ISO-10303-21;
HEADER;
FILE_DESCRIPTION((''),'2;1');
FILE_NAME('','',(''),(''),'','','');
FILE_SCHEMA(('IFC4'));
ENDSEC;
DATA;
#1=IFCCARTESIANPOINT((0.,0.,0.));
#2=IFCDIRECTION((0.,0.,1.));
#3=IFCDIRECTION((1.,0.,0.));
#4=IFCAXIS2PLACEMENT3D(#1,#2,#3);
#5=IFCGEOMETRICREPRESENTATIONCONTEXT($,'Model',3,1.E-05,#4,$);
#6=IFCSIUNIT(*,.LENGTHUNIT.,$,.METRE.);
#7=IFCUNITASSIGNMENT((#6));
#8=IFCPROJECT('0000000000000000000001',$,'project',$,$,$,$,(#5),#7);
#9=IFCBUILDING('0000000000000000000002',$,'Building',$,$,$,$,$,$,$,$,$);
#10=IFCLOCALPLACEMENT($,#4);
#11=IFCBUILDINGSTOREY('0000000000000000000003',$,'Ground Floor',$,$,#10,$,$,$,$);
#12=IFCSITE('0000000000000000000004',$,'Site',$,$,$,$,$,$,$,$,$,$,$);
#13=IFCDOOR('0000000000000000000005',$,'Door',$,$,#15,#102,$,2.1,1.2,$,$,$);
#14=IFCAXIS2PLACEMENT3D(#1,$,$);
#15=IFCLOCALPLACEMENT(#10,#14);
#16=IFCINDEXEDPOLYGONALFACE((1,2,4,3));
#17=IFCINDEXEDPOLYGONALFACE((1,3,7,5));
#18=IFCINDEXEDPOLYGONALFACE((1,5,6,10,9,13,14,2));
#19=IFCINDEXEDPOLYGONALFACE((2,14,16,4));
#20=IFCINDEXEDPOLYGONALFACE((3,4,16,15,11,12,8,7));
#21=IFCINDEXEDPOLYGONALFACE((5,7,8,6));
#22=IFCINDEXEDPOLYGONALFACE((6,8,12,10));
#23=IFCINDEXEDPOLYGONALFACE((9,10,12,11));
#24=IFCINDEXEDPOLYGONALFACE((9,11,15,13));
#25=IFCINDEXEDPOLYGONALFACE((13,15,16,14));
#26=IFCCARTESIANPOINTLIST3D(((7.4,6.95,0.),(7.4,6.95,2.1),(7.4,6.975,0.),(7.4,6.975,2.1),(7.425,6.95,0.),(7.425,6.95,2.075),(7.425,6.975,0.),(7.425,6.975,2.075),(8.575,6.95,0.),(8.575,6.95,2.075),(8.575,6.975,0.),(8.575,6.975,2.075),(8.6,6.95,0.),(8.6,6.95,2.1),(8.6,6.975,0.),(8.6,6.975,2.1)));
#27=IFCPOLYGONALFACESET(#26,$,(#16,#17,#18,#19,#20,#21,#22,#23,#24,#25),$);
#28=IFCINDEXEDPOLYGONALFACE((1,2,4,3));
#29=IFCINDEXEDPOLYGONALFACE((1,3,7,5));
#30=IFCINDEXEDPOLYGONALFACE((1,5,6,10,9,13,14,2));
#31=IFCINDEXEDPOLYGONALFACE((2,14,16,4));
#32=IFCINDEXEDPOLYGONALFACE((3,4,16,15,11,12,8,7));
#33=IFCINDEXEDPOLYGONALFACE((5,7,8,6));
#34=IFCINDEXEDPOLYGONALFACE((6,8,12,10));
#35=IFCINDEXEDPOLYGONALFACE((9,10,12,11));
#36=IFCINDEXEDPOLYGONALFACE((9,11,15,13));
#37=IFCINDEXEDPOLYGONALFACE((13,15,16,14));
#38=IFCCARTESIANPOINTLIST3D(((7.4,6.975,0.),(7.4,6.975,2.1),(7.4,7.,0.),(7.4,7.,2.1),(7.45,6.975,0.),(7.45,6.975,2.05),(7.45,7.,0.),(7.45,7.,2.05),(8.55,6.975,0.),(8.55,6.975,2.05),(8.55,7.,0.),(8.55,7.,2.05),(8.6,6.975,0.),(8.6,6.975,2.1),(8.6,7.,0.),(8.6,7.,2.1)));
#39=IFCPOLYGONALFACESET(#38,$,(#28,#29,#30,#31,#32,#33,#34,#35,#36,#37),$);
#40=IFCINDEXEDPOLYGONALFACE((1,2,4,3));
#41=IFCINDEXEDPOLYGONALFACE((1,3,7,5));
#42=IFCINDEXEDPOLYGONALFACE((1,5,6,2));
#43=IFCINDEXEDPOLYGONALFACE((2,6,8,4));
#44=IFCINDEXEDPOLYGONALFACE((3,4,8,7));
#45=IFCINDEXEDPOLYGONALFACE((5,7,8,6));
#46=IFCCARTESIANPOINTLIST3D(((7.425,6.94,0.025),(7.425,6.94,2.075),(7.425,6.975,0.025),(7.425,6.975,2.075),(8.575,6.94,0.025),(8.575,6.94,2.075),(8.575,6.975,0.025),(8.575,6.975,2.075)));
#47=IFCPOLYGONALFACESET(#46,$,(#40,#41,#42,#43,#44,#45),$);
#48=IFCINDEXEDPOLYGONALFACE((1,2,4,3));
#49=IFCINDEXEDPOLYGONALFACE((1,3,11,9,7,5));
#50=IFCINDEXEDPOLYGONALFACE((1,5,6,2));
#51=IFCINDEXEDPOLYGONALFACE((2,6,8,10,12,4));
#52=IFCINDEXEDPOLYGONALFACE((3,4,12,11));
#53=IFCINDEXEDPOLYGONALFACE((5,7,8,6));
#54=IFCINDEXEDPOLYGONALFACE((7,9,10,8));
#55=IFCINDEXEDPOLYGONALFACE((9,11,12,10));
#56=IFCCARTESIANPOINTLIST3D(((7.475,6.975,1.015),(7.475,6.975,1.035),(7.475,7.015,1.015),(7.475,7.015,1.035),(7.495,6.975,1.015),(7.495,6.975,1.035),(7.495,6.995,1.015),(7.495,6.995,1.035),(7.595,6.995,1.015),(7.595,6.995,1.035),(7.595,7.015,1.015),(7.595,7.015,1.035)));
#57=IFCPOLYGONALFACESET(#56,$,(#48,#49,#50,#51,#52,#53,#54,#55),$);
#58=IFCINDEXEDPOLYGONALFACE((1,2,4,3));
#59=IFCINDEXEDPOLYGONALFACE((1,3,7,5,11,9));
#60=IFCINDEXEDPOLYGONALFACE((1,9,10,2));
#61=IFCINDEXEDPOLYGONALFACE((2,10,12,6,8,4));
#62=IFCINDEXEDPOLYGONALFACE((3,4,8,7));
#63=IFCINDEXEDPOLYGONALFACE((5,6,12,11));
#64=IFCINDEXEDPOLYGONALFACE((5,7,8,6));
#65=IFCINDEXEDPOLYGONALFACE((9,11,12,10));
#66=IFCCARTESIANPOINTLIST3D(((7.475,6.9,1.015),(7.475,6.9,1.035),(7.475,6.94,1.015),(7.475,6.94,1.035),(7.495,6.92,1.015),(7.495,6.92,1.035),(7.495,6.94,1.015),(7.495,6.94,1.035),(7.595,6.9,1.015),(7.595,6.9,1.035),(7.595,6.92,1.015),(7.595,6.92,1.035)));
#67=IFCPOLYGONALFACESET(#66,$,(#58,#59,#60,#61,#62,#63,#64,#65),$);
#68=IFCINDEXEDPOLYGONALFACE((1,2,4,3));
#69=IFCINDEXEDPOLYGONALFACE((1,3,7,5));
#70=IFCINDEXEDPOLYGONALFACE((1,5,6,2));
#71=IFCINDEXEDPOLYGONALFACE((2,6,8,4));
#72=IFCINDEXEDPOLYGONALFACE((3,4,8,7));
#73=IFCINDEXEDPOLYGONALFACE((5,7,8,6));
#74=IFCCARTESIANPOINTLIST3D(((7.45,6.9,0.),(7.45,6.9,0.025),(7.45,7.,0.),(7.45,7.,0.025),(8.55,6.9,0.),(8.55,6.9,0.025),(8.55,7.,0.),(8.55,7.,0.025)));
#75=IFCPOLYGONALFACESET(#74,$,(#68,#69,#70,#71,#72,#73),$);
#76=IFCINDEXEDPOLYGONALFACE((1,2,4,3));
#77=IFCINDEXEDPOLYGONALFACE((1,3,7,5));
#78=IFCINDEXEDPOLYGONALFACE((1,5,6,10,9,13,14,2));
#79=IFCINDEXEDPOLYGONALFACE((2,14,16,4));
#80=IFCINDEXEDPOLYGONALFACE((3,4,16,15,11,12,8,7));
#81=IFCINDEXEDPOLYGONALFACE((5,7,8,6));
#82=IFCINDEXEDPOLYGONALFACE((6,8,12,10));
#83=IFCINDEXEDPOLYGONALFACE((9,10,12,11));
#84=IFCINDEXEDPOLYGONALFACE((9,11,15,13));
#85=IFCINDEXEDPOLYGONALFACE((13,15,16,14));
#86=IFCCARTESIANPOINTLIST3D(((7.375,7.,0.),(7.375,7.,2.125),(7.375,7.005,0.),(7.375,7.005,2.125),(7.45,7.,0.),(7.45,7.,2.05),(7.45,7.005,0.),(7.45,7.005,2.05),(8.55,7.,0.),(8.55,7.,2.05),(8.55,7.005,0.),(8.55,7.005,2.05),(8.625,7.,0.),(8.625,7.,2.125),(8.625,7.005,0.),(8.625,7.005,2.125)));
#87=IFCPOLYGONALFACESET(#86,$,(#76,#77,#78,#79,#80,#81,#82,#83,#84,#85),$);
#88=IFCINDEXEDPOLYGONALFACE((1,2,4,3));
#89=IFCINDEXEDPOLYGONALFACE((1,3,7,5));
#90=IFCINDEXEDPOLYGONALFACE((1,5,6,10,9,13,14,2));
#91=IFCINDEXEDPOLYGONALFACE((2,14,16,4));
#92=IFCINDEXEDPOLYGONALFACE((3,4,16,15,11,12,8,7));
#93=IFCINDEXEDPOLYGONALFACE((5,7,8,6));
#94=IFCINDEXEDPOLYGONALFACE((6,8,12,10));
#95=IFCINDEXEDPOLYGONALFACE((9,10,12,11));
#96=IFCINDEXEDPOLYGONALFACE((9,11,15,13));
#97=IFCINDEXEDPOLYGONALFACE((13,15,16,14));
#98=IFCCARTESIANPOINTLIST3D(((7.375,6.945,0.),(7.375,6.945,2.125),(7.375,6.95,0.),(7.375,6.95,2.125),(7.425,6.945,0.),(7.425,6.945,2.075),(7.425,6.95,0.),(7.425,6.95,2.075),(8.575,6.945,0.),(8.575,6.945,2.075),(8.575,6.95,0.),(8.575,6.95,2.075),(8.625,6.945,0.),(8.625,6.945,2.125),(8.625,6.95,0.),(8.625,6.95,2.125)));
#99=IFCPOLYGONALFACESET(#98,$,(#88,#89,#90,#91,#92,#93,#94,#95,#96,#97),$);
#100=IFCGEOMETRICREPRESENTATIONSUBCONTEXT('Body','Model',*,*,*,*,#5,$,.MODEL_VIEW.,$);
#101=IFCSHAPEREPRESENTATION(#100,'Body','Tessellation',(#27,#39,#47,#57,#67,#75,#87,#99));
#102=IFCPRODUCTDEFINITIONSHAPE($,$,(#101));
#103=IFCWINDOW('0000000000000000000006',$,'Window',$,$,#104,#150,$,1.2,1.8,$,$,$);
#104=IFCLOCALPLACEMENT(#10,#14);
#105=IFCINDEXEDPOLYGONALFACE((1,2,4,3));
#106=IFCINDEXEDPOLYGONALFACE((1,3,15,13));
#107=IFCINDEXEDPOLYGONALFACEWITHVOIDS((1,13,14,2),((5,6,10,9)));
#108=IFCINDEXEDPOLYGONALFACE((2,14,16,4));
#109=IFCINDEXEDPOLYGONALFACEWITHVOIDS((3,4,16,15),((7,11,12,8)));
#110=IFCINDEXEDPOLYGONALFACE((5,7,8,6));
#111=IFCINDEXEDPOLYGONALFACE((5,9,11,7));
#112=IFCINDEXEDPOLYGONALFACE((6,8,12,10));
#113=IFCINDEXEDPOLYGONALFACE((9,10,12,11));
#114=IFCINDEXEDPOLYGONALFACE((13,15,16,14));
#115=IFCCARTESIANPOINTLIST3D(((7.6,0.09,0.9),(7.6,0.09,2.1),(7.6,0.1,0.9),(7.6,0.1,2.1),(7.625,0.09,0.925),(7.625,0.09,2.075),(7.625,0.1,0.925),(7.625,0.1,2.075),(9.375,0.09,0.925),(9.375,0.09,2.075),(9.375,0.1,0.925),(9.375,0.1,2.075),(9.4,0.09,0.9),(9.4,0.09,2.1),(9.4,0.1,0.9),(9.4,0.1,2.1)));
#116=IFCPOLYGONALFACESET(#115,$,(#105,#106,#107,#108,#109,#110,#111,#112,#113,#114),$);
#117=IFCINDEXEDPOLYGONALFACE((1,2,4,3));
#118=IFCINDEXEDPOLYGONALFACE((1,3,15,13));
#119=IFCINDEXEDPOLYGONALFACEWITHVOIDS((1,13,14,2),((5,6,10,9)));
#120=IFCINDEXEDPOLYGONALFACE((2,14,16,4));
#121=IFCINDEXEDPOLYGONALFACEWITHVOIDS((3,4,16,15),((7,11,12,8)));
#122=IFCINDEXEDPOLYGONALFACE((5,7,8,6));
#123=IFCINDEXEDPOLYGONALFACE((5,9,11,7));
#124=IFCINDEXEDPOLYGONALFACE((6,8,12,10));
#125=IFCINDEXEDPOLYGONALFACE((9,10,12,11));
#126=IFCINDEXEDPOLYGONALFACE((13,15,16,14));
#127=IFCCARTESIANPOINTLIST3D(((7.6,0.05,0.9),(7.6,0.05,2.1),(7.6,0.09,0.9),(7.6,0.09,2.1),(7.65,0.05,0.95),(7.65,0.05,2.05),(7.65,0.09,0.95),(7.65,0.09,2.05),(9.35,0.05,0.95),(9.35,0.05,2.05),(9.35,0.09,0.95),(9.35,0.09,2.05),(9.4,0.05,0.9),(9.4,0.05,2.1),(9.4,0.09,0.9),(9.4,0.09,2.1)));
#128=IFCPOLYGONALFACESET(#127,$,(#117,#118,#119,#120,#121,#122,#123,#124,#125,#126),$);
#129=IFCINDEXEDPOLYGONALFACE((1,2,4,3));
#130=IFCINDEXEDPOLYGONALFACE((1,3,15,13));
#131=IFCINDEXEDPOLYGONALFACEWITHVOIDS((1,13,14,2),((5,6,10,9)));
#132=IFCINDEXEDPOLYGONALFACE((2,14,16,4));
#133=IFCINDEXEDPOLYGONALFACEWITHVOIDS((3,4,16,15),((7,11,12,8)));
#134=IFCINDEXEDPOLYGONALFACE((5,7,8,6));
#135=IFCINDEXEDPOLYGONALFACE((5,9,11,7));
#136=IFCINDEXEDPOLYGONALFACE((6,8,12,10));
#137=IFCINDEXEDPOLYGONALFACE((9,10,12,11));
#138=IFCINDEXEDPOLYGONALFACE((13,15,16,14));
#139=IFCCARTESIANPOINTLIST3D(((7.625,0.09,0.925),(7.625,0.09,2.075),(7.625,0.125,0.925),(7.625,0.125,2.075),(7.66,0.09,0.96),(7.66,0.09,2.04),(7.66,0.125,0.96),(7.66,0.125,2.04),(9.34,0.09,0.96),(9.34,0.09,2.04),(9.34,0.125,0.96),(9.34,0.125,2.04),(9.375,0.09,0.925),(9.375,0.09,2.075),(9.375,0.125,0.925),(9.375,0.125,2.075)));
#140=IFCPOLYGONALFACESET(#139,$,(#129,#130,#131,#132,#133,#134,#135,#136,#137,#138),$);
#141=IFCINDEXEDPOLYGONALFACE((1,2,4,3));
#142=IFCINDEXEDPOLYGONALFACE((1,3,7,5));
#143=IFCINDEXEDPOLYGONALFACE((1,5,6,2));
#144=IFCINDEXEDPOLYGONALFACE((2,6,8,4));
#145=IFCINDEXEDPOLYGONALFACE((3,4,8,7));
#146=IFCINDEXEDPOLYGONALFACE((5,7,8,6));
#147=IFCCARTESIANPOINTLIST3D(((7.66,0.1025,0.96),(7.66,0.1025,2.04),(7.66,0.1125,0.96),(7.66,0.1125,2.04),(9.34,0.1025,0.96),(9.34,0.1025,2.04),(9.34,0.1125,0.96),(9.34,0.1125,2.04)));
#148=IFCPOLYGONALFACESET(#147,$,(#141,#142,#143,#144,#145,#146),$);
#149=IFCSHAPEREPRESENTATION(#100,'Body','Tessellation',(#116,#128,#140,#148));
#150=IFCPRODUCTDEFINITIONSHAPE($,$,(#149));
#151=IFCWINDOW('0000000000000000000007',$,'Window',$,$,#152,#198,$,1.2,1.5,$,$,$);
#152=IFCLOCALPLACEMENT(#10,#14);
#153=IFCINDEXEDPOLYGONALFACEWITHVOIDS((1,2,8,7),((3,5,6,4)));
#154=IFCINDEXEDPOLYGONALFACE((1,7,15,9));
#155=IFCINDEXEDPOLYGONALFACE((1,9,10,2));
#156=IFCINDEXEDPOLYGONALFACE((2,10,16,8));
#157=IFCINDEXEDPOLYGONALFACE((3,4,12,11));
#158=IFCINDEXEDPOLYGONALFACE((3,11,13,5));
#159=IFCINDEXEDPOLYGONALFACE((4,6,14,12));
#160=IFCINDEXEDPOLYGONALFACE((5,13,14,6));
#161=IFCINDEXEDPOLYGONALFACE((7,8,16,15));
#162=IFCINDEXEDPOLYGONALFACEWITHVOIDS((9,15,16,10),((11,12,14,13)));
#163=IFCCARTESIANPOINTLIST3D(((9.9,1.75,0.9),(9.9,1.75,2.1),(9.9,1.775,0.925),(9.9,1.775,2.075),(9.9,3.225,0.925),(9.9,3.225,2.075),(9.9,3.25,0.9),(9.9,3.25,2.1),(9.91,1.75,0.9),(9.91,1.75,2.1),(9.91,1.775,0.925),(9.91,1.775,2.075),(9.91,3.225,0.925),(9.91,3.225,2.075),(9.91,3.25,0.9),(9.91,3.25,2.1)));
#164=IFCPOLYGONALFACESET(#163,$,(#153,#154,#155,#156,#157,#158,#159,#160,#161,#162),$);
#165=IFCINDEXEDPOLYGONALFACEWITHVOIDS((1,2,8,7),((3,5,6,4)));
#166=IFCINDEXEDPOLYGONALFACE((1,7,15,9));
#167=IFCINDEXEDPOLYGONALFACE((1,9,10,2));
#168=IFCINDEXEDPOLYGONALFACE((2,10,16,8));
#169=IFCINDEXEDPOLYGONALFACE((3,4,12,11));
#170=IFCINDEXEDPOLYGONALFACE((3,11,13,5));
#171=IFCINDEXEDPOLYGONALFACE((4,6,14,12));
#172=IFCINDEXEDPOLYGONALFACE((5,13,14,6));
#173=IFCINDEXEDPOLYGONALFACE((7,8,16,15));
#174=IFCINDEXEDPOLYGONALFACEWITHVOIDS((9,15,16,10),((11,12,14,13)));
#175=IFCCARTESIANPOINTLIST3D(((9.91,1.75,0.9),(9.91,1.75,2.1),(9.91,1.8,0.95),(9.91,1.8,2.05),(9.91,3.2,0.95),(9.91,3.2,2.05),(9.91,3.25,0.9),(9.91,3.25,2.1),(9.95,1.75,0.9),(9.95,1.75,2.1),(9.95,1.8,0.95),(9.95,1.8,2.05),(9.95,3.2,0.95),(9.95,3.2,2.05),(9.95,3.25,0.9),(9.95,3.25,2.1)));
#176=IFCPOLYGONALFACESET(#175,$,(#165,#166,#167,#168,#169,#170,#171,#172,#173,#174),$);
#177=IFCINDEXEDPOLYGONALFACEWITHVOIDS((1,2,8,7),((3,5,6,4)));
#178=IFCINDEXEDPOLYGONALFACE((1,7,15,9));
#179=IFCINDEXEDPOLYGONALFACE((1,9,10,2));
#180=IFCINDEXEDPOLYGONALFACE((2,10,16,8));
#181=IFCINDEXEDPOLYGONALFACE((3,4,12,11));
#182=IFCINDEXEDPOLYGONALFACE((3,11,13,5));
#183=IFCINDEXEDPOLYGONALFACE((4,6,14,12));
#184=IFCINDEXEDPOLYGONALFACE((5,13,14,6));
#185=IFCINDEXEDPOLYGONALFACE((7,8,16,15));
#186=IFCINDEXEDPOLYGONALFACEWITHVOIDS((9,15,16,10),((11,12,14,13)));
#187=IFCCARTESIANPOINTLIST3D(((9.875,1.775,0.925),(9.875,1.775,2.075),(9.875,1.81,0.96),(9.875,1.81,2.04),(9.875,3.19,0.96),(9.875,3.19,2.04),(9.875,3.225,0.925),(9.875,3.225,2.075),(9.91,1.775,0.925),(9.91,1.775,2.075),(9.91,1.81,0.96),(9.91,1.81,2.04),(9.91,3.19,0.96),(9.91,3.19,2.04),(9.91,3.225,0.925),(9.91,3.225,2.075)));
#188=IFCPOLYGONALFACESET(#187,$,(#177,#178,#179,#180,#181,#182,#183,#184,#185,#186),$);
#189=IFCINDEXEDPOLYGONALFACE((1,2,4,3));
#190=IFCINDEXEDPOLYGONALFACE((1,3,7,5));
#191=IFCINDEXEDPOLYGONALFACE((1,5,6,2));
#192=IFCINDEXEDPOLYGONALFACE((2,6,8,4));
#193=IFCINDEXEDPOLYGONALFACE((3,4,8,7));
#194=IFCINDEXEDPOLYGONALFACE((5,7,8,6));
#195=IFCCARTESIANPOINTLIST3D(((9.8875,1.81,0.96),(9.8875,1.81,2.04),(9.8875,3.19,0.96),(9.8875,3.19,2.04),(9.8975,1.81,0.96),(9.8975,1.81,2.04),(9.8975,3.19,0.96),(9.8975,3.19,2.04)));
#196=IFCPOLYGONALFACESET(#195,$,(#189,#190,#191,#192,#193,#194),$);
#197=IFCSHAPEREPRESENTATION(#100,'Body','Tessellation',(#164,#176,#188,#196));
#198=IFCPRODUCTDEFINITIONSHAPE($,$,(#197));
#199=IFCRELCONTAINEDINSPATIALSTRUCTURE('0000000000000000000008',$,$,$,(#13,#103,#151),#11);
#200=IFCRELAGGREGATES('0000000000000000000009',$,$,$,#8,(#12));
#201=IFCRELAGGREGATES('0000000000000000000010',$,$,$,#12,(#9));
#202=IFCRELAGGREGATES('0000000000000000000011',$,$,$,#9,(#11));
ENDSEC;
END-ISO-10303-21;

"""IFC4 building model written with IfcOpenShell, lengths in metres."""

from ifc_helpers import new_model, si_unit, frame, origin_with_axes, place, context, subcontext, project, spatial, line, indexed_curve, outline, extrude, element, save


model = new_model("IFC4")

# Units and contexts
model_context = context("Model", 3, precision=1e-05, world=origin_with_axes())
body_context = subcontext(model_context, "Body", "Model", "MODEL_VIEW")
ifc_project = project(units=[si_unit("LENGTHUNIT", "METRE")], contexts=[model_context])

# Site, building, storey
site = spatial("IfcSite", under=ifc_project, Name="Site")
building = spatial("IfcBuilding", under=site, Name="Building")
storey_placement = place(None, origin_with_axes())
storey = spatial("IfcBuildingStorey", under=building, at=storey_placement, Name="Ground Floor")

# Door
door_1_placement = place(storey_placement, frame((8.6, 7.0, 0.0), z_axis=(0.0, 0.0, 1.0), x_axis=(-1.0, 0.0, 0.0)))
element("IfcDoor", 1, at=door_1_placement, inside=storey, Name="Door", OverallHeight=2.1, OverallWidth=1.2, context=body_context, shape_type="SweptSolid", body=[
    extrude(outline(indexed_curve([(0.0, 0.0), (0.0, 2.1), (1.2, 2.1), (1.2, 0.0), (1.175, 0.0), (1.175, 2.075), (0.025, 2.075), (0.025, 0.0)], segments=[line(1, 2, 3, 4, 5, 6, 7, 8, 1)])), frame((0.0, 0.025, 0.0), z_axis=(0.0, -1.0, 0.0), x_axis=(1.0, 0.0, 0.0)), (0.0, 0.0, -1.0), 0.025),
    extrude(outline(indexed_curve([(0.0, 0.0), (0.0, 2.1), (1.2, 2.1), (1.2, 0.0), (1.15, 0.0), (1.15, 2.05), (0.05, 2.05), (0.05, 0.0)], segments=[line(1, 2, 3, 4, 5, 6, 7, 8, 1)])), frame((0.0, 0.0, 0.0), z_axis=(0.0, -1.0, 0.0), x_axis=(1.0, 0.0, 0.0)), (0.0, 0.0, -1.0), 0.025),
    extrude(outline(indexed_curve([(0.0, 0.0), (1.15, 0.0), (1.15, 0.035), (0.0, 0.035)], segments=[line(1, 2, 3, 4, 1)])), frame((0.025, 0.025, 0.025), z_axis=(0.0, 0.0, 1.0), x_axis=(1.0, 0.0, 0.0)), (0.0, 0.0, 1.0), 2.05),
    extrude(outline(indexed_curve([(0.0, 0.0), (0.0, -0.04), (-0.12, -0.04), (-0.12, -0.02), (-0.02, -0.02), (-0.02, 0.0)], segments=[line(1, 2, 3, 4, 5, 6, 1)])), frame((1.125, 0.025, 1.015), z_axis=(0.0, 0.0, 1.0), x_axis=(1.0, 0.0, 0.0)), (0.0, 0.0, 1.0), 0.02),
    extrude(outline(indexed_curve([(0.0, 0.0), (0.0, 0.04), (-0.12, 0.04), (-0.12, 0.02), (-0.02, 0.02), (-0.02, 0.0)], segments=[line(1, 2, 3, 4, 5, 6, 1)])), frame((1.125, 0.06, 1.015), z_axis=(0.0, 0.0, 1.0), x_axis=(1.0, 0.0, 0.0)), (0.0, 0.0, 1.0), 0.02),
    extrude(outline(indexed_curve([(0.0, 0.0), (1.1, 0.0), (1.1, 0.1), (0.0, 0.1)], segments=[line(1, 2, 3, 4, 1)])), frame((0.05, 0.0, 0.0), z_axis=(0.0, 0.0, 1.0), x_axis=(1.0, 0.0, 0.0)), (0.0, 0.0, 1.0), 0.025),
    extrude(outline(indexed_curve([(0.0, 0.0), (0.0, 2.125), (1.25, 2.125), (1.25, 0.0), (1.175, 0.0), (1.175, 2.05), (0.075, 2.05), (0.075, 0.0)], segments=[line(1, 2, 3, 4, 5, 6, 7, 8, 1)])), frame((-0.025, -0.005, 0.0), z_axis=(0.0, -1.0, 0.0), x_axis=(1.0, 0.0, 0.0)), (0.0, 0.0, -1.0), 0.005),
    extrude(outline(indexed_curve([(0.0, 0.0), (0.0, 2.125), (1.25, 2.125), (1.25, 0.0), (1.2, 0.0), (1.2, 2.075), (0.05, 2.075), (0.05, 0.0)], segments=[line(1, 2, 3, 4, 5, 6, 7, 8, 1)])), frame((-0.025, 0.05, 0.0), z_axis=(0.0, -1.0, 0.0), x_axis=(1.0, 0.0, 0.0)), (0.0, 0.0, -1.0), 0.005),
])

# Windows
window_1_placement = place(storey_placement, frame((7.6, 0.0, 0.9), z_axis=(0.0, 0.0, 1.0), x_axis=(1.0, 0.0, 0.0)))
element("IfcWindow", 2, at=window_1_placement, inside=storey, Name="Window", OverallHeight=1.2, OverallWidth=1.8, context=body_context, shape_type="SweptSolid", body=[
    extrude(outline(indexed_curve([(0.0, 0.0), (1.8, 0.0), (1.8, 1.2), (0.0, 1.2)], segments=[line(1, 2, 3, 4, 1)]), holes=[indexed_curve([(0.025, 0.025), (1.775, 0.025), (1.775, 1.175), (0.025, 1.175)], segments=[line(1, 2, 3, 4, 1)])]), frame((0.0, 0.09, 0.0), z_axis=(0.0, -1.0, 0.0), x_axis=(1.0, 0.0, 0.0)), (0.0, 0.0, -1.0), 0.01),
    extrude(outline(indexed_curve([(0.0, 0.0), (1.8, 0.0), (1.8, 1.2), (0.0, 1.2)], segments=[line(1, 2, 3, 4, 1)]), holes=[indexed_curve([(0.05, 0.05), (1.75, 0.05), (1.75, 1.15), (0.05, 1.15)], segments=[line(1, 2, 3, 4, 1)])]), frame((0.0, 0.05, 0.0), z_axis=(0.0, -1.0, 0.0), x_axis=(1.0, 0.0, 0.0)), (0.0, 0.0, -1.0), 0.04),
    extrude(outline(indexed_curve([(0.0, 0.0), (1.75, 0.0), (1.75, 1.15), (0.0, 1.15)], segments=[line(1, 2, 3, 4, 1)]), holes=[indexed_curve([(0.035, 0.035), (1.715, 0.035), (1.715, 1.115), (0.035, 1.115)], segments=[line(1, 2, 3, 4, 1)])]), frame((0.025, 0.09, 0.025), z_axis=(0.0, -1.0, 0.0), x_axis=(1.0, 0.0, 0.0)), (0.0, 0.0, -1.0), 0.035),
    extrude(outline(indexed_curve([(0.035, 0.035), (1.715, 0.035), (1.715, 1.115), (0.035, 1.115)], segments=[line(1, 2, 3, 4, 1)])), frame((0.025, 0.1025, 0.025), z_axis=(0.0, -1.0, 0.0), x_axis=(1.0, 0.0, 0.0)), (0.0, 0.0, -1.0), 0.01),
])
for number, where, z_axis, x_axis, name in (
    (3, (10.0, 1.75, 0.9), (0.0, 0.0, 1.0), (0.0, 1.0, 0.0), "Window"),
):
    element("IfcWindow", number, at=place(storey_placement, frame(where, z_axis=z_axis, x_axis=x_axis)), inside=storey, Name=name, OverallHeight=1.2, OverallWidth=1.5, context=body_context, shape_type="SweptSolid", body=[
        extrude(outline(indexed_curve([(0.0, 0.0), (1.5, 0.0), (1.5, 1.2), (0.0, 1.2)], segments=[line(1, 2, 3, 4, 1)]), holes=[indexed_curve([(0.025, 0.025), (1.475, 0.025), (1.475, 1.175), (0.025, 1.175)], segments=[line(1, 2, 3, 4, 1)])]), frame((0.0, 0.09, 0.0), z_axis=(0.0, -1.0, 0.0), x_axis=(1.0, 0.0, 0.0)), (0.0, 0.0, -1.0), 0.01),
        extrude(outline(indexed_curve([(0.0, 0.0), (1.5, 0.0), (1.5, 1.2), (0.0, 1.2)], segments=[line(1, 2, 3, 4, 1)]), holes=[indexed_curve([(0.05, 0.05), (1.45, 0.05), (1.45, 1.15), (0.05, 1.15)], segments=[line(1, 2, 3, 4, 1)])]), frame((0.0, 0.05, 0.0), z_axis=(0.0, -1.0, 0.0), x_axis=(1.0, 0.0, 0.0)), (0.0, 0.0, -1.0), 0.04),
        extrude(outline(indexed_curve([(0.0, 0.0), (1.45, 0.0), (1.45, 1.15), (0.0, 1.15)], segments=[line(1, 2, 3, 4, 1)]), holes=[indexed_curve([(0.035, 0.035), (1.415, 0.035), (1.415, 1.115), (0.035, 1.115)], segments=[line(1, 2, 3, 4, 1)])]), frame((0.025, 0.09, 0.025), z_axis=(0.0, -1.0, 0.0), x_axis=(1.0, 0.0, 0.0)), (0.0, 0.0, -1.0), 0.035),
        extrude(outline(indexed_curve([(0.035, 0.035), (1.415, 0.035), (1.415, 1.115), (0.035, 1.115)], segments=[line(1, 2, 3, 4, 1)])), frame((0.025, 0.1025, 0.025), z_axis=(0.0, -1.0, 0.0), x_axis=(1.0, 0.0, 0.0)), (0.0, 0.0, -1.0), 0.01),
    ])

save(model, "model.ifc")
